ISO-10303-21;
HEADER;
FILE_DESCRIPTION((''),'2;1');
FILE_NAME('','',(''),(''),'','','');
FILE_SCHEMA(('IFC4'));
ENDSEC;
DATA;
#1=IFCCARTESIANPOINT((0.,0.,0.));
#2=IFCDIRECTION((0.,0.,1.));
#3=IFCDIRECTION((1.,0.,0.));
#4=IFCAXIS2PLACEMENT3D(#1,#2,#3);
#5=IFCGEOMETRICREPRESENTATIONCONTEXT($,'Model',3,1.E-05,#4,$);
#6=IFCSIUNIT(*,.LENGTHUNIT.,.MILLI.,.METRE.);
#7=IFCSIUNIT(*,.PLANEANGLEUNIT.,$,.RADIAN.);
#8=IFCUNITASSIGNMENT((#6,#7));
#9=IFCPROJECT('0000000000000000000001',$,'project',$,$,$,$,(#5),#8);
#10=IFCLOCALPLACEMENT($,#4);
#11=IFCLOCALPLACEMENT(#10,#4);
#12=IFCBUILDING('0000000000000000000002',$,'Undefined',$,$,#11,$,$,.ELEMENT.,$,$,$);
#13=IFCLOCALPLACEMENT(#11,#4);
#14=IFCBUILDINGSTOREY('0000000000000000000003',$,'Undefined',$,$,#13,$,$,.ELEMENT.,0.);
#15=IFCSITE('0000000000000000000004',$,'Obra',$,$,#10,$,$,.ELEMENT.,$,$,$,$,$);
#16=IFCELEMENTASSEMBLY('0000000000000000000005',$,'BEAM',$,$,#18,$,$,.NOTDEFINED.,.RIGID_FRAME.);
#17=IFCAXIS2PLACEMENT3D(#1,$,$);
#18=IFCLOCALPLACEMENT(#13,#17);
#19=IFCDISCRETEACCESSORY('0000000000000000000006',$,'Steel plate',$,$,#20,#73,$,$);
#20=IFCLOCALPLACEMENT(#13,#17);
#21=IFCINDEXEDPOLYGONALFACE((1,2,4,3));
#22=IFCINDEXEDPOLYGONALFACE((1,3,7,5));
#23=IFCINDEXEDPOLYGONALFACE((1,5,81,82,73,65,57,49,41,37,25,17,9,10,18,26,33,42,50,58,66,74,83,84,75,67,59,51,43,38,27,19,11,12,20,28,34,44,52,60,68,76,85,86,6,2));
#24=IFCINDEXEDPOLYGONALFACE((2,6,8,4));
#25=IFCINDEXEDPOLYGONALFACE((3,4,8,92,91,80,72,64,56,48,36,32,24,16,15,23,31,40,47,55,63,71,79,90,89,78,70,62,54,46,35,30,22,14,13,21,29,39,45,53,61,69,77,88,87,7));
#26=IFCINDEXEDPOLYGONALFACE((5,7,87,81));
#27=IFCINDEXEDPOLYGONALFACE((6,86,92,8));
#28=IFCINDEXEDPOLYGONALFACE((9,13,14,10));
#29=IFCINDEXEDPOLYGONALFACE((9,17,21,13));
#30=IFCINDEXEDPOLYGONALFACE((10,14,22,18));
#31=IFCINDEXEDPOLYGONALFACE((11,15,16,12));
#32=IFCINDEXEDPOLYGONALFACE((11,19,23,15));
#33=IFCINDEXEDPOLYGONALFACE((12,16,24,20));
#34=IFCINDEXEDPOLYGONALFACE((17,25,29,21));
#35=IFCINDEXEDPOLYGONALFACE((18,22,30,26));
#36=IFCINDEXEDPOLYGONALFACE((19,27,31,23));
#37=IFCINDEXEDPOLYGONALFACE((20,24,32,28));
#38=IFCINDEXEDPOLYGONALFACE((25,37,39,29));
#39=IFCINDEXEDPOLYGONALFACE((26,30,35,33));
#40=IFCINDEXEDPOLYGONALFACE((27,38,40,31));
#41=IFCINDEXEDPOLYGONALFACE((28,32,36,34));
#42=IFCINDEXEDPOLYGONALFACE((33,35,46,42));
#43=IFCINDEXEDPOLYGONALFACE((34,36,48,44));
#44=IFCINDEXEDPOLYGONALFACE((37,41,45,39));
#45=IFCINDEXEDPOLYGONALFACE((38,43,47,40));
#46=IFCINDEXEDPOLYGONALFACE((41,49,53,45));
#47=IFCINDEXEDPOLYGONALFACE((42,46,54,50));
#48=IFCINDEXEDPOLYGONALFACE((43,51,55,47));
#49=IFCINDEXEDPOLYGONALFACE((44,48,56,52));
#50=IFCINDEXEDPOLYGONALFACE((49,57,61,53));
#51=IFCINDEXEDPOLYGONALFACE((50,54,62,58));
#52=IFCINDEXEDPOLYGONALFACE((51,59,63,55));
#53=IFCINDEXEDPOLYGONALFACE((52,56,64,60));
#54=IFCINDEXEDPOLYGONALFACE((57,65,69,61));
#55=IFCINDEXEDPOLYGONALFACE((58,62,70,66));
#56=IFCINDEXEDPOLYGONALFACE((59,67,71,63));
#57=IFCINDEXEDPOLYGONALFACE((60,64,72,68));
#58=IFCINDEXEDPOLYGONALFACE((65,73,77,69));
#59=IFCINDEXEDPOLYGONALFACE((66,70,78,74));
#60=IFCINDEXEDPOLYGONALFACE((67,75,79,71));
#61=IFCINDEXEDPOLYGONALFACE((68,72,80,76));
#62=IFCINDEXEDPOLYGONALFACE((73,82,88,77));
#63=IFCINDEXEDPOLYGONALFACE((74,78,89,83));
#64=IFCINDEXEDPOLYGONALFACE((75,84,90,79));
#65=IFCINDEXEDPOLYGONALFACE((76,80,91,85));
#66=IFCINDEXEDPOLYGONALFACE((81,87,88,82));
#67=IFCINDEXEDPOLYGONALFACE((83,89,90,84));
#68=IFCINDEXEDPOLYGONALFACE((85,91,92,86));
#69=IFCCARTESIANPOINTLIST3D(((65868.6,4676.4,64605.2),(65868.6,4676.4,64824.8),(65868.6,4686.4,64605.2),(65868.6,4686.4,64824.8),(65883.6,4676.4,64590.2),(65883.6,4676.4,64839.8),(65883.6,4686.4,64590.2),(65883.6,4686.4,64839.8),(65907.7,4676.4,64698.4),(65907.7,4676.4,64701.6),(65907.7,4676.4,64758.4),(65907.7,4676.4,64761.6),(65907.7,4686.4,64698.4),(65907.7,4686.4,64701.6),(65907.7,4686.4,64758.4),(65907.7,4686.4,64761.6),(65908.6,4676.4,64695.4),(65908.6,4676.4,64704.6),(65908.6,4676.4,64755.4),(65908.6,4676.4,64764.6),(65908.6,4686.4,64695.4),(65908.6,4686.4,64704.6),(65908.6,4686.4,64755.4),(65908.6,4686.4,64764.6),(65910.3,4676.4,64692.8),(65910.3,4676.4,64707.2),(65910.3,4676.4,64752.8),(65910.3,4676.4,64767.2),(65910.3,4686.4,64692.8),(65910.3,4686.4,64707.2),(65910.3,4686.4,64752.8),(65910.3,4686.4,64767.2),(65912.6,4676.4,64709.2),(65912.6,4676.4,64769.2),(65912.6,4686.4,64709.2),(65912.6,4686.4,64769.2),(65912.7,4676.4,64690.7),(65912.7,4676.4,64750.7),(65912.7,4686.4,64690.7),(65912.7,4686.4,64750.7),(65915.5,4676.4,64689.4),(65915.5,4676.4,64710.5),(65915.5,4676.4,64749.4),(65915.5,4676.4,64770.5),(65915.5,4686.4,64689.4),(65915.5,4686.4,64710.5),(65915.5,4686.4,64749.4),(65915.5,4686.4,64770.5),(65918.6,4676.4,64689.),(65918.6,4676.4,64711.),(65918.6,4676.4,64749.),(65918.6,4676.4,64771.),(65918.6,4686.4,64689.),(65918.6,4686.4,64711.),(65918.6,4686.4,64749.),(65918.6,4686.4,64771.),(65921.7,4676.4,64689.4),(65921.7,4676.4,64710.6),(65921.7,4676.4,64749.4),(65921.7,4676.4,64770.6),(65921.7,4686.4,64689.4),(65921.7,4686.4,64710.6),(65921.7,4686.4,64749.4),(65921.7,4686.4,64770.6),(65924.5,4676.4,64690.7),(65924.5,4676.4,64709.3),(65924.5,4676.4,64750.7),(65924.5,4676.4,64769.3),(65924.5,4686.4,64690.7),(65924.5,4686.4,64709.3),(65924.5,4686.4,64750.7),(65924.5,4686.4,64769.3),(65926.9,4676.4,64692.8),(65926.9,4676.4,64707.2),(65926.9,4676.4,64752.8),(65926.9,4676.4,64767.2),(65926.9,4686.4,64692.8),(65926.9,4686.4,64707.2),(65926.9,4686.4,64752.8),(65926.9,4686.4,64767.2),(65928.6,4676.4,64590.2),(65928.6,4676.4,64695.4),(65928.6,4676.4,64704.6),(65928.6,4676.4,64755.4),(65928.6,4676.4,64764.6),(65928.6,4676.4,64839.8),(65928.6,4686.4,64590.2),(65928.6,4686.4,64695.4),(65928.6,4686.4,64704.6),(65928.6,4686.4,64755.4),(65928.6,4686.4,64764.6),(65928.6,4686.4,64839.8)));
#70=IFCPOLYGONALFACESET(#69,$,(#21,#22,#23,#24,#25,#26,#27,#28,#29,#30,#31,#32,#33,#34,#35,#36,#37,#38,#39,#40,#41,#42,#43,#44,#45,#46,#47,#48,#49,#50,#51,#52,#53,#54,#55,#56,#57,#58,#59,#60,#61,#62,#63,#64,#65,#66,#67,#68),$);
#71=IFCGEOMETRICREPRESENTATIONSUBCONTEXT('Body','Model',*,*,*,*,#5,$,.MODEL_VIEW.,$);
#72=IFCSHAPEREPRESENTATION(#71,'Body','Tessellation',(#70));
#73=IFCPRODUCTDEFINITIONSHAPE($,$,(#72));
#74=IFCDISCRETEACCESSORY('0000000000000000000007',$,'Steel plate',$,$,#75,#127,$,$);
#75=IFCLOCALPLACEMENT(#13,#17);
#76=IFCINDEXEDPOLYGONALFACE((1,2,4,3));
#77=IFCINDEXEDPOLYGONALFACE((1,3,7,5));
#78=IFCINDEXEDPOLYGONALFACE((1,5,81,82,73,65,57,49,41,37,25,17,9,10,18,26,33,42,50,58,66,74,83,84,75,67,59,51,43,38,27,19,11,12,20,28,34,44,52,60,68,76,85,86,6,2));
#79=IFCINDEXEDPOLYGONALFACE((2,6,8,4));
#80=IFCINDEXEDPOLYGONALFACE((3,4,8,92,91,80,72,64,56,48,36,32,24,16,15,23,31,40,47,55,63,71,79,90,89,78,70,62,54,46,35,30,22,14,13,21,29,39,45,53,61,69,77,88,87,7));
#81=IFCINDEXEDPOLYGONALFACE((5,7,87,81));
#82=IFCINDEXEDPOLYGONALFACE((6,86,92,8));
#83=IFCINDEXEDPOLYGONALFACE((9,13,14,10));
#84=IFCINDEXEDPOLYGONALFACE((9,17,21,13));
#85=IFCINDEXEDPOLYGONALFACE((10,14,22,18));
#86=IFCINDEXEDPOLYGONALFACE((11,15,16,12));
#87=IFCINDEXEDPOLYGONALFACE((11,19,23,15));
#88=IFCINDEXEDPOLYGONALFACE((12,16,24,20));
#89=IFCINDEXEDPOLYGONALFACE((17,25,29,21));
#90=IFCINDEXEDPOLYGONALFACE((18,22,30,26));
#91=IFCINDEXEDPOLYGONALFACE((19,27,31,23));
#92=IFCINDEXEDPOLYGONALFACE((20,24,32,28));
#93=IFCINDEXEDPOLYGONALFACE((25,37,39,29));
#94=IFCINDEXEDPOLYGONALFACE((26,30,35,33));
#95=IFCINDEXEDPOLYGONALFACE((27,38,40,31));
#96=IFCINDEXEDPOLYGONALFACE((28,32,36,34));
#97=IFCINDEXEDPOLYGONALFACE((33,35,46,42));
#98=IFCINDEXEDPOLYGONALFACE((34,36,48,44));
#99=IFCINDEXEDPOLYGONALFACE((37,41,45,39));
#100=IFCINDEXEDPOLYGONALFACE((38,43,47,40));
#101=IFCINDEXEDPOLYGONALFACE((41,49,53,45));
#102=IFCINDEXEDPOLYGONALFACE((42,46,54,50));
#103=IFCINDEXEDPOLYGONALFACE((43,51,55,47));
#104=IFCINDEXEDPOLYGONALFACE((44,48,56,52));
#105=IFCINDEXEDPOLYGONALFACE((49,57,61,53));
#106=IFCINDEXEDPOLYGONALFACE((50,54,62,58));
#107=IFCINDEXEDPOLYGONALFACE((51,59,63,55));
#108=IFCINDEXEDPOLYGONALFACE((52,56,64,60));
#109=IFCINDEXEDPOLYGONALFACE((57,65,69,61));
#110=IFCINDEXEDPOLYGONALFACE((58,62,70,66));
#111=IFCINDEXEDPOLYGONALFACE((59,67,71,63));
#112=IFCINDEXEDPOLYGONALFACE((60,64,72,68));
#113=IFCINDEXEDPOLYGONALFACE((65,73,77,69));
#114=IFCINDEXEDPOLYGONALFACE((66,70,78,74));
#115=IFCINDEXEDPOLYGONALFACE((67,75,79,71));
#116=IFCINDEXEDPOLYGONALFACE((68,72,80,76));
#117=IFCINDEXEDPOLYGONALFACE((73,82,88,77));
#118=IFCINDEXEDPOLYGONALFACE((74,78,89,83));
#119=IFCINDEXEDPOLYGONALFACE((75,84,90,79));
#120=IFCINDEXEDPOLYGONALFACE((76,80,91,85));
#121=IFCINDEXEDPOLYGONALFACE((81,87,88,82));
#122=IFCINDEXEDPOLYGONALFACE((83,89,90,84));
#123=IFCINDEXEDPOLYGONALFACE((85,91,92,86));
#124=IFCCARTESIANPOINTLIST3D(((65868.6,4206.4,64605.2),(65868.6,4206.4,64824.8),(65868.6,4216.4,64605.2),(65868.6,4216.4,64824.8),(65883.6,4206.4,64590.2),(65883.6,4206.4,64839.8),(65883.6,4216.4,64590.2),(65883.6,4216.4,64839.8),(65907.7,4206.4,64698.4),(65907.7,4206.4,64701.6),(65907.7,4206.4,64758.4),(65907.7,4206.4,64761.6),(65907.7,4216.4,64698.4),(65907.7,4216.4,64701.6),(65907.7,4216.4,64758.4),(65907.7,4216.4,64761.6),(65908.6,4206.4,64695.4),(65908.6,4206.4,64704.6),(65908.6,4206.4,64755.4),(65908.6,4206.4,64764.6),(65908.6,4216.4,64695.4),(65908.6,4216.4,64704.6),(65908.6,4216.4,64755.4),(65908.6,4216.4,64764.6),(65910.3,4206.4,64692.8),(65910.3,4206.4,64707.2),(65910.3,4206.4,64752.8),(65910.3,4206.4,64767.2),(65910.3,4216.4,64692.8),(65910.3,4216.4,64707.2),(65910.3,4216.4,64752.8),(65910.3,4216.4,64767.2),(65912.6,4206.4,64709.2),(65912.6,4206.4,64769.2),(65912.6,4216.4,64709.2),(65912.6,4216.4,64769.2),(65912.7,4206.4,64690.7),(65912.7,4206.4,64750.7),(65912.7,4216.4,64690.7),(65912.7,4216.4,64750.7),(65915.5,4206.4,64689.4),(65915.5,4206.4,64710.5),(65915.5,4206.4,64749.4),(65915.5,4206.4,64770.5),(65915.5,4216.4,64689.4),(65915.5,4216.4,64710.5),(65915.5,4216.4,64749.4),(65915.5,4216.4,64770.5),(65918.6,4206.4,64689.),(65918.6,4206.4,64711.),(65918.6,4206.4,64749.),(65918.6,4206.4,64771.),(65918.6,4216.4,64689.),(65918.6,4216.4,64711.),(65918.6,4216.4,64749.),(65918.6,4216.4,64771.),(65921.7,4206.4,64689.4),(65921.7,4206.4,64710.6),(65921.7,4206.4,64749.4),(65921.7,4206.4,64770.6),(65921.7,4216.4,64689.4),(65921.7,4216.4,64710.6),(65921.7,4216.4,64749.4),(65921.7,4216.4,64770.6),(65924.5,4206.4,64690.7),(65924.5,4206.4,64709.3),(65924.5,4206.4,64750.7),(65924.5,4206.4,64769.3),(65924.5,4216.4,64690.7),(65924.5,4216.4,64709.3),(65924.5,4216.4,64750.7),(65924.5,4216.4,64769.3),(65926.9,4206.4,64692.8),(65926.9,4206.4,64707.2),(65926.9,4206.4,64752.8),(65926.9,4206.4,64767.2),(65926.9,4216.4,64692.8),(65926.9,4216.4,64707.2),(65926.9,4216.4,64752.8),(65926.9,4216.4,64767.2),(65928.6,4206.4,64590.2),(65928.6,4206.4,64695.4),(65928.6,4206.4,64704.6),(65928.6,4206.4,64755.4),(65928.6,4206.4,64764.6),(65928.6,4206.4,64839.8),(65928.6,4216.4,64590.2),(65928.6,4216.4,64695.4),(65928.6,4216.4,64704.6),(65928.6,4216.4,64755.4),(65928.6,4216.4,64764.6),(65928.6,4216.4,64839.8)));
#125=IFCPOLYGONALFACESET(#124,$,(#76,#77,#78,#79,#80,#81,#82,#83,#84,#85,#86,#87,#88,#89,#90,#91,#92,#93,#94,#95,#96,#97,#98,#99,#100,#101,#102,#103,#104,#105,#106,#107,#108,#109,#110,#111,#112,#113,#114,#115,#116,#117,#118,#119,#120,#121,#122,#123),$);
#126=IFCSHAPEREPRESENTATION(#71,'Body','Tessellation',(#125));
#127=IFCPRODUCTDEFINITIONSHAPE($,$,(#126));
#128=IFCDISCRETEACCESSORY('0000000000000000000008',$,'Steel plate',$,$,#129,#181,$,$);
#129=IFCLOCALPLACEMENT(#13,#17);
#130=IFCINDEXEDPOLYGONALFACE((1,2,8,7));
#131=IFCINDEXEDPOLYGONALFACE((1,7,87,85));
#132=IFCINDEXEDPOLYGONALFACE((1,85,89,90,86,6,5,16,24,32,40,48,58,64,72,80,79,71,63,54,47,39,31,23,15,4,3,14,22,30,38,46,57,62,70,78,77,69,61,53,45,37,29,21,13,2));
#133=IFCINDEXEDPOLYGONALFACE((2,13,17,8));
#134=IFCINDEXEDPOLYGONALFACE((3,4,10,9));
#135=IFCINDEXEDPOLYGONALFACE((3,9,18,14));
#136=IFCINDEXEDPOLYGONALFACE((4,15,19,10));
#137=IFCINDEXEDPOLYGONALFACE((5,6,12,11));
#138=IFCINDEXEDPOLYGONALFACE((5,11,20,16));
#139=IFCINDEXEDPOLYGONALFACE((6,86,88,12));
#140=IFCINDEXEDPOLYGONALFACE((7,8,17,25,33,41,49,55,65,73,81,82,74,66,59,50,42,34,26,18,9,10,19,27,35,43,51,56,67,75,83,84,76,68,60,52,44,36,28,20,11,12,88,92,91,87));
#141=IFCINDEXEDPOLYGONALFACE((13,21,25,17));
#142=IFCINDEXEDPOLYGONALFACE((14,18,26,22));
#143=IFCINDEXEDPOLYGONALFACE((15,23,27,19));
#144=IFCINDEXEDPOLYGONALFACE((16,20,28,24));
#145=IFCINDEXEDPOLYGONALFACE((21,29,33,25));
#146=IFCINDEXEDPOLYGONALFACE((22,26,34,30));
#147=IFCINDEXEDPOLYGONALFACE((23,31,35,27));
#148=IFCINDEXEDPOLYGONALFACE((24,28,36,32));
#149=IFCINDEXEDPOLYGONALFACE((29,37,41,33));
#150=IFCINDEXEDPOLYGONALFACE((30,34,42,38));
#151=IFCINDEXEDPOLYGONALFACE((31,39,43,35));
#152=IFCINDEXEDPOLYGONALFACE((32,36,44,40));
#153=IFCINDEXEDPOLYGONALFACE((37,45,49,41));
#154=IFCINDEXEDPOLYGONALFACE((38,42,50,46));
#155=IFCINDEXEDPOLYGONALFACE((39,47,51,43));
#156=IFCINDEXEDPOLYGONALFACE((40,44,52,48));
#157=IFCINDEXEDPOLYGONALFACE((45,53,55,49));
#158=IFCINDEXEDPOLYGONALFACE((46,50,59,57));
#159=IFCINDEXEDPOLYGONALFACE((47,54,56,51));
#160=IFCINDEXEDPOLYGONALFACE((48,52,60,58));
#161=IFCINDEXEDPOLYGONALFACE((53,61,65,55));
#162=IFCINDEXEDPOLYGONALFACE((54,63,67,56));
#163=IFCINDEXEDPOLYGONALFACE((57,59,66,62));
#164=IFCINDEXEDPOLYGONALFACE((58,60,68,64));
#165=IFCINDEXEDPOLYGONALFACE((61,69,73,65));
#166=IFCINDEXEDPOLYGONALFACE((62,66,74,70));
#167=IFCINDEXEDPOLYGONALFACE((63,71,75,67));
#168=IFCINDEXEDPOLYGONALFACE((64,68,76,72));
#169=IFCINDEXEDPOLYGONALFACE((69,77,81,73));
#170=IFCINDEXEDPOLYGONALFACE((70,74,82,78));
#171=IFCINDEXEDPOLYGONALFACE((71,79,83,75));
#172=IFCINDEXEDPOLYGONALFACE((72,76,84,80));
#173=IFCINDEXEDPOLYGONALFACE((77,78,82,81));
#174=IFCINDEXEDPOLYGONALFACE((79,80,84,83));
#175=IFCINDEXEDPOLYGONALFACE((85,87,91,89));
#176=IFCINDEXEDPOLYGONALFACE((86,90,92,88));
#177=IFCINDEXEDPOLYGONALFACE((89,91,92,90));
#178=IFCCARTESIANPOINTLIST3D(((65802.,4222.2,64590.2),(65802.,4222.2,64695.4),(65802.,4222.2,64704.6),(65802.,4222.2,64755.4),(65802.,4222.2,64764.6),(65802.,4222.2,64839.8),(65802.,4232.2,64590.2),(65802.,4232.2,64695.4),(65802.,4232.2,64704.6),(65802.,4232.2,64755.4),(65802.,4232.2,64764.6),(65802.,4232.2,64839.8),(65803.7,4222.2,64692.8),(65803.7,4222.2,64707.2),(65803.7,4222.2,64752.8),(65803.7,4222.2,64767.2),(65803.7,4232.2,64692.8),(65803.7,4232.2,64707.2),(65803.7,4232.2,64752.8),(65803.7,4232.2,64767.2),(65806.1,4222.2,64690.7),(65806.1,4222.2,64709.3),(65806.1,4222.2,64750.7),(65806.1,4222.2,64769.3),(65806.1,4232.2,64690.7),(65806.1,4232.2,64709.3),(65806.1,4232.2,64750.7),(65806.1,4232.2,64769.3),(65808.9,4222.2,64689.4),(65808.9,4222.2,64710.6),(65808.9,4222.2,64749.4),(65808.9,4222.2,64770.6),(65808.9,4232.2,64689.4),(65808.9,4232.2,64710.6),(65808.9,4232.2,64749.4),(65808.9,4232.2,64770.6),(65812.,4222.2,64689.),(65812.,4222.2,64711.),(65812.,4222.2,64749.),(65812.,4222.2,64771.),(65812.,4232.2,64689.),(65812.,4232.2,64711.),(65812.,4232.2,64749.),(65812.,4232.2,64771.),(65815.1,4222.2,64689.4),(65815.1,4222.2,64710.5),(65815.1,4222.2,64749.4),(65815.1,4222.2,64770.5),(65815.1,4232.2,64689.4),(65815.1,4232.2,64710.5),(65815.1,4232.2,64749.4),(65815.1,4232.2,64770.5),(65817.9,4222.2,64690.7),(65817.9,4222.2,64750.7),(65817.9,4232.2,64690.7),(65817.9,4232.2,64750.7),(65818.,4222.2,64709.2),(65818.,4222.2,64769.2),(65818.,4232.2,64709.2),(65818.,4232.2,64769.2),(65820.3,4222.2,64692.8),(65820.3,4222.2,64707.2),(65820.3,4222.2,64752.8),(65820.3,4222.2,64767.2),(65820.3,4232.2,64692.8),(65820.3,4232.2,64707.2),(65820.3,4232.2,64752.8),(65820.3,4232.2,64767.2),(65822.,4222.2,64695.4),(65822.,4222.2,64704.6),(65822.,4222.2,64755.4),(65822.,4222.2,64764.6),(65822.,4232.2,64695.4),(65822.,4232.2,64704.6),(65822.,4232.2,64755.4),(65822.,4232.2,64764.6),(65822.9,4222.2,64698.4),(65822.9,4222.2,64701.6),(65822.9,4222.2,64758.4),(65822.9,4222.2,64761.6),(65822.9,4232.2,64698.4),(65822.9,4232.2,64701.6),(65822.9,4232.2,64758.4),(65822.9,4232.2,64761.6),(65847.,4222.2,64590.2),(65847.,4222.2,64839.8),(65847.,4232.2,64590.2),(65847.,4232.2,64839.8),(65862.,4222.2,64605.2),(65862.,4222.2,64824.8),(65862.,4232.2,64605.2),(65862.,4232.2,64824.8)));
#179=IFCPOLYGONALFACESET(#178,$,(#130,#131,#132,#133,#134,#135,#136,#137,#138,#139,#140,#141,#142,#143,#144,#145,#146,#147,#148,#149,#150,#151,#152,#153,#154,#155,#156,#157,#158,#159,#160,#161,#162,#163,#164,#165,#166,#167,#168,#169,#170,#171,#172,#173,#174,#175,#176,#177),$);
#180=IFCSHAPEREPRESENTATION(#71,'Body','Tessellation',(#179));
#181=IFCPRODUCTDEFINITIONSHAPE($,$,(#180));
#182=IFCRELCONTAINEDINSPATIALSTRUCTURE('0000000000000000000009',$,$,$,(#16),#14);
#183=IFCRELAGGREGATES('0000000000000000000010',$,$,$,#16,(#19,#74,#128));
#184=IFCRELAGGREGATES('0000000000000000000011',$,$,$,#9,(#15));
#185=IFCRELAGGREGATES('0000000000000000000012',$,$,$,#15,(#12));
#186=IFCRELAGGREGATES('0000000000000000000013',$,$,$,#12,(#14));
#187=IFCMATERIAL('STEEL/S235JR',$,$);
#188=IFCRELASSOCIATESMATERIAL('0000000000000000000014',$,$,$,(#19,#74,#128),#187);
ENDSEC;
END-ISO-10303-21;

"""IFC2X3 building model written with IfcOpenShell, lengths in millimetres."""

from ifc_helpers import new_model, si_unit, frame, origin_with_axes, origin_2d_with_axis, place, context, subcontext, project, spatial, polyline, circle, outline, extrude, source, transform, mapped, material, element, aggregate, save


model = new_model("IFC2X3")

# Units and contexts
model_context = context("Model", 3, precision=1e-05, world=origin_with_axes())
body_context = subcontext(model_context, "Body", "Model", "MODEL_VIEW")
ifc_project = project(units=[si_unit("LENGTHUNIT", "METRE", prefix="MILLI"), si_unit("PLANEANGLEUNIT", "RADIAN")], contexts=[model_context])

# Site, building, storey
site_placement = place(None, origin_with_axes())
site = spatial("IfcSite", under=ifc_project, at=site_placement, Name="Obra", CompositionType="ELEMENT")
building_placement = place(site_placement, origin_with_axes())
building = spatial("IfcBuilding", under=site, at=building_placement, Name="Undefined", CompositionType="ELEMENT")
storey_placement = place(building_placement, origin_with_axes())
storey = spatial("IfcBuildingStorey", under=building, at=storey_placement, Name="Undefined", CompositionType="ELEMENT", Elevation=0.0)

# Shared definitions
ifc_material = material(Name="STEEL/S235JR")

# Element assembly, discrete accessories, openings
assembly_1_placement = place(storey_placement, origin_with_axes())
assembly_1 = element("IfcElementAssembly", 1, at=assembly_1_placement, inside=storey, Name="BEAM", AssemblyPlace="NOTDEFINED", PredefinedType="RIGID_FRAME")
discrete_accessory_1_placement = place(assembly_1_placement, frame((65928.6, 4681.4, 64590.2), z_axis=(0.0, 1.0, 0.0), x_axis=(-1.0, 0.0, 0.0)))
discrete_accessory_1 = element("IfcDiscreteAccessory", 2, at=discrete_accessory_1_placement, material=ifc_material, Name="Steel plate", context=body_context, shape_type="SweptSolid", body=[
    extrude(outline(polyline([(0.0, 0.0), (45.0, 0.0), (60.0, 15.0), (60.0, 234.6), (45.0, 249.6), (0.0, 249.6), (0.0, 0.0)])), frame((0.0, 0.0, -5.0), z_axis=(0.0, 0.0, 1.0), x_axis=(1.0, 0.0, 0.0)), (0.0, 0.0, 1.0), 10.0),
])
shared_shape_1 = source(origin_with_axes(), body_context, "Body", "SweptSolid", [
    extrude(circle(Radius=11.0, at=origin_2d_with_axis()), frame((0.0, -13.2, 0.0), z_axis=(0.0, 1.0, 0.0), x_axis=(1.0, 0.0, 0.0)), (0.0, 0.0, 1.0), 10.2),
])
opening_1_placement = place(assembly_1_placement, frame((65878.6, 4689.5, 64850.0), z_axis=(1.0, 0.0, 0.0), x_axis=(0.0, 0.0, -1.0)))
element("IfcOpeningElement", 3, at=opening_1_placement, cuts=discrete_accessory_1, ObjectType="Opening", context=body_context, shape_type="MappedRepresentation", body=[
    mapped(shared_shape_1, transform((90.0, 0.0, 40.0))),
    mapped(shared_shape_1, transform((150.0, 0.0, 40.0))),
])
discrete_accessory_2_placement = place(assembly_1_placement, frame((65928.6, 4211.4, 64590.2), z_axis=(0.0, 1.0, 0.0), x_axis=(-1.0, 0.0, 0.0)))
discrete_accessory_2 = element("IfcDiscreteAccessory", 4, at=discrete_accessory_2_placement, material=ifc_material, Name="Steel plate", context=body_context, shape_type="SweptSolid", body=[
    extrude(outline(polyline([(0.0, 0.0), (45.0, 0.0), (60.0, 15.0), (60.0, 234.6), (45.0, 249.6), (0.0, 249.6), (0.0, 0.0)])), frame((0.0, 0.0, -5.0), z_axis=(0.0, 0.0, 1.0), x_axis=(1.0, 0.0, 0.0)), (0.0, 0.0, 1.0), 10.0),
])
opening_2_placement = place(assembly_1_placement, frame((65878.6, 4219.5, 64850.0), z_axis=(1.0, 0.0, 0.0), x_axis=(0.0, 0.0, -1.0)))
element("IfcOpeningElement", 5, at=opening_2_placement, cuts=discrete_accessory_2, ObjectType="Opening", context=body_context, shape_type="MappedRepresentation", body=[
    mapped(shared_shape_1, transform((90.0, 0.0, 40.0))),
    mapped(shared_shape_1, transform((150.0, 0.0, 40.0))),
])
discrete_accessory_3_placement = place(assembly_1_placement, frame((65802.0, 4227.2, 64590.2), z_axis=(0.0, -1.0, 0.0), x_axis=(1.0, 0.0, 0.0)))
discrete_accessory_3 = element("IfcDiscreteAccessory", 6, at=discrete_accessory_3_placement, material=ifc_material, Name="Steel plate", context=body_context, shape_type="SweptSolid", body=[
    extrude(outline(polyline([(0.0, 0.0), (45.0, 0.0), (60.0, 15.0), (60.0, 234.6), (45.0, 249.6), (0.0, 249.6), (0.0, 0.0)])), frame((0.0, 0.0, -5.0), z_axis=(0.0, 0.0, 1.0), x_axis=(1.0, 0.0, 0.0)), (0.0, 0.0, 1.0), 10.0),
])
opening_3_placement = place(assembly_1_placement, frame((65852.0, 4219.1, 64850.0), z_axis=(-1.0, 0.0, 0.0), x_axis=(0.0, 0.0, -1.0)))
element("IfcOpeningElement", 7, at=opening_3_placement, cuts=discrete_accessory_3, ObjectType="Opening", context=body_context, shape_type="MappedRepresentation", body=[
    mapped(shared_shape_1, transform((90.0, 0.0, 40.0))),
    mapped(shared_shape_1, transform((150.0, 0.0, 40.0))),
])
aggregate(assembly_1, [discrete_accessory_1, discrete_accessory_2, discrete_accessory_3])

save(model, "model.ifc")
